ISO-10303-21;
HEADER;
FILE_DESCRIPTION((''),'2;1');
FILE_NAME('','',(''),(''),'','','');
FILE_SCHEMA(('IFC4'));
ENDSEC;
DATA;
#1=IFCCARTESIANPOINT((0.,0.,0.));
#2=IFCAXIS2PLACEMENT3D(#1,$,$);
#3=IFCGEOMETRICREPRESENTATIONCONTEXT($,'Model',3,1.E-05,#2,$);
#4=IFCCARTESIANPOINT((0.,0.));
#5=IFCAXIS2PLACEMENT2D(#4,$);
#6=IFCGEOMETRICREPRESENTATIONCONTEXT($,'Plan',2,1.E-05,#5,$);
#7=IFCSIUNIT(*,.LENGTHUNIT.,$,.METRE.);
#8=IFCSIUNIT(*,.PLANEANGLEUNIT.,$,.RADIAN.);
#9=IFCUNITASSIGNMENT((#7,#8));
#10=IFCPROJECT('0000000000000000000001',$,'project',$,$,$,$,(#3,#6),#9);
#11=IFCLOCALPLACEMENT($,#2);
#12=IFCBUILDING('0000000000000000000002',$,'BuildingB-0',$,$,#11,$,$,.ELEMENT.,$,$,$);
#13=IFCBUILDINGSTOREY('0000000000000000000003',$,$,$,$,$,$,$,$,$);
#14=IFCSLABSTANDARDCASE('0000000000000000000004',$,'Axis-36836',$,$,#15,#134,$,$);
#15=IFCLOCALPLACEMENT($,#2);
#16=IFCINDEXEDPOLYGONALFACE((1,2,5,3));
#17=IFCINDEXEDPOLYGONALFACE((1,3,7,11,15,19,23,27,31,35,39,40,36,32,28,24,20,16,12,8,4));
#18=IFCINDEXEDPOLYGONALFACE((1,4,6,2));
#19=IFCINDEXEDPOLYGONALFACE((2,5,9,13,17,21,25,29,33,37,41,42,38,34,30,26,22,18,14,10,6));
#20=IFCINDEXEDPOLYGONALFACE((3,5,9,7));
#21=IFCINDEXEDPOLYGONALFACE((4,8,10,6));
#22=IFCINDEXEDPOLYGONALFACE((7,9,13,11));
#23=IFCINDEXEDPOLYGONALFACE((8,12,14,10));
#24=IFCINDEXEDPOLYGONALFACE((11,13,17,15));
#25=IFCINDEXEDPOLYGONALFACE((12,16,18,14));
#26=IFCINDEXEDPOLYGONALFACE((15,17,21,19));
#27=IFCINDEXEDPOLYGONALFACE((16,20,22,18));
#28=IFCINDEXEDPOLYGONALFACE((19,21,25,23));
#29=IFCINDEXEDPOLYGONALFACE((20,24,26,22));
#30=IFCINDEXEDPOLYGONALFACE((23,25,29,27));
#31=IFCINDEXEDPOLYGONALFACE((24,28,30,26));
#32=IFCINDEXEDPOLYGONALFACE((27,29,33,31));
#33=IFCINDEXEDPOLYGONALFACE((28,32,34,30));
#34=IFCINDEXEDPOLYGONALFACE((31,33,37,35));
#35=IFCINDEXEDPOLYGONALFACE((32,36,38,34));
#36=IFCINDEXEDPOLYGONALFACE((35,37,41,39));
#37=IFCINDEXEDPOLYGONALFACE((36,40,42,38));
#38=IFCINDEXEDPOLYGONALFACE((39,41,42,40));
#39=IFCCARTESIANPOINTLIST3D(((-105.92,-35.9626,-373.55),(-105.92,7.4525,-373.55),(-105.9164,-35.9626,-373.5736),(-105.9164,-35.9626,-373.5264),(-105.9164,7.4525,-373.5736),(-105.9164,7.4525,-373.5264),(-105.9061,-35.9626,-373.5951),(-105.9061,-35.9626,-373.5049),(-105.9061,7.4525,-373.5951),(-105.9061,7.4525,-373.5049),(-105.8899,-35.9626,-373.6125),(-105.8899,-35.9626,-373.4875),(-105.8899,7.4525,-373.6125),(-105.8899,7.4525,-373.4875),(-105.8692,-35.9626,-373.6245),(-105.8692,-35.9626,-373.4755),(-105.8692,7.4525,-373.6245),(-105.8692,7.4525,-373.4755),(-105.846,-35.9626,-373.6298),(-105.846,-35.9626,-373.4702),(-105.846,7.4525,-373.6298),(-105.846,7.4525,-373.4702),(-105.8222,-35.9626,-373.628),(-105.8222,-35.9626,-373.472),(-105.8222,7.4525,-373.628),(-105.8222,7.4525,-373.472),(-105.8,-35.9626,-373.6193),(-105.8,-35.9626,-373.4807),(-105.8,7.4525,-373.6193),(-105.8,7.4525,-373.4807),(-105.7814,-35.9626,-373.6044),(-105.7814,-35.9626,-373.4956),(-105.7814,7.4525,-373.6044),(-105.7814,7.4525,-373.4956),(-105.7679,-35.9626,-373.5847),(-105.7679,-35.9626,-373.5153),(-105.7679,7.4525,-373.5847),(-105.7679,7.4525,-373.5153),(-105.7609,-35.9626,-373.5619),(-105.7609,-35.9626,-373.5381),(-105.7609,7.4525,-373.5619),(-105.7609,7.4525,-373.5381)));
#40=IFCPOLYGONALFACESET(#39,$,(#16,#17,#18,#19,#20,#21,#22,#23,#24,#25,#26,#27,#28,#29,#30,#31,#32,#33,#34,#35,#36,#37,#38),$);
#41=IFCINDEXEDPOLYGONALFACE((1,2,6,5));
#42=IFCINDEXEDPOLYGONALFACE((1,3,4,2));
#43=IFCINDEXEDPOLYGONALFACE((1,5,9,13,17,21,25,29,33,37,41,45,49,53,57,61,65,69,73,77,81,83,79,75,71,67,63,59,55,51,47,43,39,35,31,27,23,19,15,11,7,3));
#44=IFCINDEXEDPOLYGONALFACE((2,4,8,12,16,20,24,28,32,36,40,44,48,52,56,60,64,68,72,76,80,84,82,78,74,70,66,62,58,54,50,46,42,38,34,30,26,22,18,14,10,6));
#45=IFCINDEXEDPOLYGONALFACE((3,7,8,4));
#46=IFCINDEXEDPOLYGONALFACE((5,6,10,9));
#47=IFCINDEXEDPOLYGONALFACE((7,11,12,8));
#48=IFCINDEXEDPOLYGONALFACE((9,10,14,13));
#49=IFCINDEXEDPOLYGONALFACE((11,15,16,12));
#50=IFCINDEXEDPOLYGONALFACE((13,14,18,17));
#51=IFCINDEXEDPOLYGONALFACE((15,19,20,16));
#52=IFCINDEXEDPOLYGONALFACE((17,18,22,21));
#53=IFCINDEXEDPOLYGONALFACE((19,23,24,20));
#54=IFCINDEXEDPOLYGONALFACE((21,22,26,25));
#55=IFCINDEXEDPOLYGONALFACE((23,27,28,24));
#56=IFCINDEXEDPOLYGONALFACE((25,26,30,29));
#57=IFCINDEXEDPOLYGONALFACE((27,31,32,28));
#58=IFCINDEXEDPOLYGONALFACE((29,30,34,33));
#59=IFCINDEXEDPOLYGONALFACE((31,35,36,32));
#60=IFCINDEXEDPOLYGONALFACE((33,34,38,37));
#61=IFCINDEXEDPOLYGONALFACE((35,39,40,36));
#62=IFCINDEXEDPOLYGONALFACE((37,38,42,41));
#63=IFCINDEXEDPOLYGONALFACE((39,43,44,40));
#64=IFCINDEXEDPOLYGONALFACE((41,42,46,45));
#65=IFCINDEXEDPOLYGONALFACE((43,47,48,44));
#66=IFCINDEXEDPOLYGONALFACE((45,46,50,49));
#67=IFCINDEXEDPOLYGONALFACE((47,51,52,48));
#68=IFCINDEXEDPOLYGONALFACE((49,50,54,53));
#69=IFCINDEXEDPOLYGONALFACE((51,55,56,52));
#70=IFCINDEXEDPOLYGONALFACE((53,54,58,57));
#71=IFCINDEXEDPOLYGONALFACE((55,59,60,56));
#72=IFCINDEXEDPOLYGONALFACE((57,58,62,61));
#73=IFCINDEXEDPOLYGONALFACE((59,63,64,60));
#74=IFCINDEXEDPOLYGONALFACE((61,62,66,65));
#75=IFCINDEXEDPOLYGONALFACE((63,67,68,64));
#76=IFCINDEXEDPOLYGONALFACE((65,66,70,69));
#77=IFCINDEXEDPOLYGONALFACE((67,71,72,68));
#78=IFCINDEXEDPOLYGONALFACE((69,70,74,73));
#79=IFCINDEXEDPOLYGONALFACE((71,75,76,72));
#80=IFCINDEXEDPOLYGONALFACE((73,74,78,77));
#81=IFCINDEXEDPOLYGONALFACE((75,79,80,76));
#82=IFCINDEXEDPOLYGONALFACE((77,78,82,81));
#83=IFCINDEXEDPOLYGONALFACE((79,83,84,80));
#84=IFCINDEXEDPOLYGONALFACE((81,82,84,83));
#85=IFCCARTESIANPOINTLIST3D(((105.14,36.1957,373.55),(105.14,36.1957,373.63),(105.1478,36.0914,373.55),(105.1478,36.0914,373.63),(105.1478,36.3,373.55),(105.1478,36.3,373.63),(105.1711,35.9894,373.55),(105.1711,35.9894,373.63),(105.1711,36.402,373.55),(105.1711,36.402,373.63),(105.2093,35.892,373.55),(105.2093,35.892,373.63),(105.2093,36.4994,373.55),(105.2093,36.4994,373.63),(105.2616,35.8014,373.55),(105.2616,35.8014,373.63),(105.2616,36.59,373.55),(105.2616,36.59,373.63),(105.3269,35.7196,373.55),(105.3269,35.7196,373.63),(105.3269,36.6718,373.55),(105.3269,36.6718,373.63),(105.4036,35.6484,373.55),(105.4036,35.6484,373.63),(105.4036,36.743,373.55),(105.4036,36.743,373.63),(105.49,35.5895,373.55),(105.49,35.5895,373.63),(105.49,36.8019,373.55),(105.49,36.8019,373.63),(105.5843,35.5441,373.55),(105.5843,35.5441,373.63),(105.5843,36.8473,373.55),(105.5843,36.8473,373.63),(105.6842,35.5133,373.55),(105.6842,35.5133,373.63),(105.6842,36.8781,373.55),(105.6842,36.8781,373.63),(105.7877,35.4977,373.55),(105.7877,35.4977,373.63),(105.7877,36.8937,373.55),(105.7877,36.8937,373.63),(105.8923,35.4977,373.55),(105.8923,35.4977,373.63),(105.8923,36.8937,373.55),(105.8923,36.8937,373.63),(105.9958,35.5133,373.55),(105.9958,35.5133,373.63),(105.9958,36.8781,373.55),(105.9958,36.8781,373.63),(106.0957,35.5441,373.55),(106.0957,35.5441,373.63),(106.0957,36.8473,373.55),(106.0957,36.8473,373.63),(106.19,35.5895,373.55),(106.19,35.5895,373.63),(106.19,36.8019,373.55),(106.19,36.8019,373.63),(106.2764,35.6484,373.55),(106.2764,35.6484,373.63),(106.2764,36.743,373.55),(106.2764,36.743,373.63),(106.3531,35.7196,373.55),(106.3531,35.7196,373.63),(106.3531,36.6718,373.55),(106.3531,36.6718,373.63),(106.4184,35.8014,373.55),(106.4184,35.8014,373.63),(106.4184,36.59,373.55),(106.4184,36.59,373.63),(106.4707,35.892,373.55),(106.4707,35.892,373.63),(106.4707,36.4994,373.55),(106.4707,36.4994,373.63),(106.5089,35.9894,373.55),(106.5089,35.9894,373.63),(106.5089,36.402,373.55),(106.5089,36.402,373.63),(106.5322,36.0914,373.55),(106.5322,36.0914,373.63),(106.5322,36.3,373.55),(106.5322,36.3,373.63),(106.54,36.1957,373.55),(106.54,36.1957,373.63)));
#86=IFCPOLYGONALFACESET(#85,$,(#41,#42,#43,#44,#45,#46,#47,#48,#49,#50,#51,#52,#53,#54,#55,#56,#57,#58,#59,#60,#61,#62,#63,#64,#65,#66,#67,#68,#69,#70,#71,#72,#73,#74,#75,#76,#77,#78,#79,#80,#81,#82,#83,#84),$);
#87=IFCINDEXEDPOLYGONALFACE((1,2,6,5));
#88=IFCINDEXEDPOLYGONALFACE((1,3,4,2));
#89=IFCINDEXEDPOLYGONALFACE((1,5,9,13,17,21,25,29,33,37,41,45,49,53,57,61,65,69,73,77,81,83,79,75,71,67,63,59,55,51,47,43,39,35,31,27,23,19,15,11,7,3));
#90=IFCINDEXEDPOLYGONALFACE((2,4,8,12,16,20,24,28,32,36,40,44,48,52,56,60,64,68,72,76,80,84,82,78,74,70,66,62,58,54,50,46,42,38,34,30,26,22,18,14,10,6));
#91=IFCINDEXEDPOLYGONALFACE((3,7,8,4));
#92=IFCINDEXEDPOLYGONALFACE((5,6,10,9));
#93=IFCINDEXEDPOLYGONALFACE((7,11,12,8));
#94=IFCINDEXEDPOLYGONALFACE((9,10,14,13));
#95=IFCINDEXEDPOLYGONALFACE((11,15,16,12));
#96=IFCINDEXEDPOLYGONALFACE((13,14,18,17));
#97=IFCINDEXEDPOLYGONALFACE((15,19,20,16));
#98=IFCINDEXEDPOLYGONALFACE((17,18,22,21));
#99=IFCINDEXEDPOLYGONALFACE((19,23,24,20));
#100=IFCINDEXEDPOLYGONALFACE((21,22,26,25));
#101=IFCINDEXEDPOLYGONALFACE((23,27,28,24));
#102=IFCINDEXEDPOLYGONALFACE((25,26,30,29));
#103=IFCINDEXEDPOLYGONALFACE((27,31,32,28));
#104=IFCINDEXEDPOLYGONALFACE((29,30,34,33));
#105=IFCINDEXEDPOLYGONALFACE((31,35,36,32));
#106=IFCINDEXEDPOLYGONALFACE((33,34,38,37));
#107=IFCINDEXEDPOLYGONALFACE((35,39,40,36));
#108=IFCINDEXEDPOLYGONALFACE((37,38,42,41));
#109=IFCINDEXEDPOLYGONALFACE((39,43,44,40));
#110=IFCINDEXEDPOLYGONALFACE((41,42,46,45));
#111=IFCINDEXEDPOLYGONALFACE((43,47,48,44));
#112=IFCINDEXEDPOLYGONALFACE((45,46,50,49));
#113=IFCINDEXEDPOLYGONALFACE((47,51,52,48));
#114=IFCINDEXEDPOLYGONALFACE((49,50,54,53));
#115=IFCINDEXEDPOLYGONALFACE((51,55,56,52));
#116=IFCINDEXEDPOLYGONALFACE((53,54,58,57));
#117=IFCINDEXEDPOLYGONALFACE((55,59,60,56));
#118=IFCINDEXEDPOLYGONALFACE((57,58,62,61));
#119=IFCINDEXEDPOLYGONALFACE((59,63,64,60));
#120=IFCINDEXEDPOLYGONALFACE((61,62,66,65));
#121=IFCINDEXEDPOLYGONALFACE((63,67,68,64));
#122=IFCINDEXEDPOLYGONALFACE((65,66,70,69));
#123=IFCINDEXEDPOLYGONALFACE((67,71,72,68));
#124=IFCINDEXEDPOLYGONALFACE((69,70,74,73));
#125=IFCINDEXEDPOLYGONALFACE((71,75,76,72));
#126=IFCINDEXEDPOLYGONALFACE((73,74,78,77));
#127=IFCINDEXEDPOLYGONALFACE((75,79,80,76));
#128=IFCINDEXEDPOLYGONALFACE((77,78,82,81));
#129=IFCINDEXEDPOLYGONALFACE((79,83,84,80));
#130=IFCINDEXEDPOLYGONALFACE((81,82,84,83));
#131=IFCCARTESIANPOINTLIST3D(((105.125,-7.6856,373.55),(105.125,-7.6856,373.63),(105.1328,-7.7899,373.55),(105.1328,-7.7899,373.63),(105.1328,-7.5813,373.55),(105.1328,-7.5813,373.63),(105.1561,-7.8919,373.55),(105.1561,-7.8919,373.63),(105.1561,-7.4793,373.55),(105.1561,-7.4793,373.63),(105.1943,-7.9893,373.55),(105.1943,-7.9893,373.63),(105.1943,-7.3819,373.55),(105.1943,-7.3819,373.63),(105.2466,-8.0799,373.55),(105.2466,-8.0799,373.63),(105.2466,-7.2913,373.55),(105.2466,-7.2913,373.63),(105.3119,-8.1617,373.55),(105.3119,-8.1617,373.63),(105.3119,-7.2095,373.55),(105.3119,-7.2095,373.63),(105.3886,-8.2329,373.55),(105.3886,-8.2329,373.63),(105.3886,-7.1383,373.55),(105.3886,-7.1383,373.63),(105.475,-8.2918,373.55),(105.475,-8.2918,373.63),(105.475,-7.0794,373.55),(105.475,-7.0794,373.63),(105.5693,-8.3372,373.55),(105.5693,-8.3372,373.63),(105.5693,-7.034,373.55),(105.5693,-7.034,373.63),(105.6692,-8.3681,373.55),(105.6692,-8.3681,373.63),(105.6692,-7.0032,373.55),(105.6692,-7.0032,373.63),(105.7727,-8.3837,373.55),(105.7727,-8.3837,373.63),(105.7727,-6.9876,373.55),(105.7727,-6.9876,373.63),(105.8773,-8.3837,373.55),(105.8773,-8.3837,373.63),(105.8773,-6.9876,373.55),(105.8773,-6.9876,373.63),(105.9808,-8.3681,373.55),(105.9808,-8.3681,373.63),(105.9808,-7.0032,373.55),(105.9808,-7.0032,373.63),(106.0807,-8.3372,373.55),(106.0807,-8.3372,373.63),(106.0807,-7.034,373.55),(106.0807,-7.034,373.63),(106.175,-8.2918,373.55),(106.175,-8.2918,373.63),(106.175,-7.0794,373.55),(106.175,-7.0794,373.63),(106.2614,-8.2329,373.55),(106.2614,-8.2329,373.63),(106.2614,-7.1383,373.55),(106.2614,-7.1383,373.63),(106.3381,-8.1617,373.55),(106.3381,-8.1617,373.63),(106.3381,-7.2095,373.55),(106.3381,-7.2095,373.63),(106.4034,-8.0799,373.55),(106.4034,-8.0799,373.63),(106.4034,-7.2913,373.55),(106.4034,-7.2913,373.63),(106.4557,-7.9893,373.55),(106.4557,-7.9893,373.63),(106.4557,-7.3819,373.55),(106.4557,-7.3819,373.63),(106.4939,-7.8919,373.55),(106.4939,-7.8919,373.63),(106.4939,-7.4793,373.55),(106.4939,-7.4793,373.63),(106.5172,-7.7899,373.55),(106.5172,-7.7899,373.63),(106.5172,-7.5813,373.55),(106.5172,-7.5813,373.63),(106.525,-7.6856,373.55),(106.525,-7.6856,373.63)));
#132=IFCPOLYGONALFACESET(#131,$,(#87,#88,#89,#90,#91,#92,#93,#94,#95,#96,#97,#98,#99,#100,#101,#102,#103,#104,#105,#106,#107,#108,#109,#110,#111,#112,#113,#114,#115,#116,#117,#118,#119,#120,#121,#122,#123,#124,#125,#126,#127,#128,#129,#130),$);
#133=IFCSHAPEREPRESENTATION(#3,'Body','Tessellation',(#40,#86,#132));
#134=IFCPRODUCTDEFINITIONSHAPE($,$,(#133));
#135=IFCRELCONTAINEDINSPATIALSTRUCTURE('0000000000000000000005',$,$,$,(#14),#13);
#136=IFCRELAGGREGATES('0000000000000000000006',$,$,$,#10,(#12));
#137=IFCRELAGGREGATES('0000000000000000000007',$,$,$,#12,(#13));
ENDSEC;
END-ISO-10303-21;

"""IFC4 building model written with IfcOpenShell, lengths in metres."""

from ifc_helpers import new_model, entity, si_unit, frame, origin, origin_2d, place, context, project, spatial, circle, extrude, element, save


model = new_model("IFC4")

# Units and contexts
model_context = context("Model", 3, precision=1e-05, world=origin())
plan_context = context("Plan", 2, precision=1e-05, world=origin_2d())
ifc_project = project(units=[si_unit("LENGTHUNIT", "METRE"), si_unit("PLANEANGLEUNIT", "RADIAN")], contexts=[model_context, plan_context])

# Building, storey
building_placement = place(None, origin())
building = spatial("IfcBuilding", under=ifc_project, at=building_placement, Name="BuildingB-0", CompositionType="ELEMENT")
storey = spatial("IfcBuildingStorey", under=building)

# Slab
element("IfcSlabStandardCase", 1, inside=storey, Name="Axis-36836", context=model_context, shape_type="AdvancedSweptSolid", body=[
    entity("IfcSurfaceCurveSweptAreaSolid", entity("IfcCircleProfileDef", "AREA", None, None, 0.08), None, entity("IfcPolyline", [entity("IfcCartesianPoint", [105.84, 35.9626, 373.55]), entity("IfcCartesianPoint", [105.84, -7.4525, 373.55])]), None, None, entity("IfcPlane", entity("IfcAxis2Placement3D", entity("IfcCartesianPoint", [105.84, 35.9626, 373.55]), entity("IfcDirection", [0.0, 0.0, 1.0]), entity("IfcDirection", [1.0, 0.0, 0.0])))),
    extrude(circle(Radius=0.7), frame((105.84, 36.1957, 373.55)), (0.0, 0.0, 1.0), 0.08),
    extrude(circle(Radius=0.7), frame((105.825, -7.6856, 373.55)), (0.0, 0.0, 1.0), 0.08),
])

save(model, "model.ifc")
